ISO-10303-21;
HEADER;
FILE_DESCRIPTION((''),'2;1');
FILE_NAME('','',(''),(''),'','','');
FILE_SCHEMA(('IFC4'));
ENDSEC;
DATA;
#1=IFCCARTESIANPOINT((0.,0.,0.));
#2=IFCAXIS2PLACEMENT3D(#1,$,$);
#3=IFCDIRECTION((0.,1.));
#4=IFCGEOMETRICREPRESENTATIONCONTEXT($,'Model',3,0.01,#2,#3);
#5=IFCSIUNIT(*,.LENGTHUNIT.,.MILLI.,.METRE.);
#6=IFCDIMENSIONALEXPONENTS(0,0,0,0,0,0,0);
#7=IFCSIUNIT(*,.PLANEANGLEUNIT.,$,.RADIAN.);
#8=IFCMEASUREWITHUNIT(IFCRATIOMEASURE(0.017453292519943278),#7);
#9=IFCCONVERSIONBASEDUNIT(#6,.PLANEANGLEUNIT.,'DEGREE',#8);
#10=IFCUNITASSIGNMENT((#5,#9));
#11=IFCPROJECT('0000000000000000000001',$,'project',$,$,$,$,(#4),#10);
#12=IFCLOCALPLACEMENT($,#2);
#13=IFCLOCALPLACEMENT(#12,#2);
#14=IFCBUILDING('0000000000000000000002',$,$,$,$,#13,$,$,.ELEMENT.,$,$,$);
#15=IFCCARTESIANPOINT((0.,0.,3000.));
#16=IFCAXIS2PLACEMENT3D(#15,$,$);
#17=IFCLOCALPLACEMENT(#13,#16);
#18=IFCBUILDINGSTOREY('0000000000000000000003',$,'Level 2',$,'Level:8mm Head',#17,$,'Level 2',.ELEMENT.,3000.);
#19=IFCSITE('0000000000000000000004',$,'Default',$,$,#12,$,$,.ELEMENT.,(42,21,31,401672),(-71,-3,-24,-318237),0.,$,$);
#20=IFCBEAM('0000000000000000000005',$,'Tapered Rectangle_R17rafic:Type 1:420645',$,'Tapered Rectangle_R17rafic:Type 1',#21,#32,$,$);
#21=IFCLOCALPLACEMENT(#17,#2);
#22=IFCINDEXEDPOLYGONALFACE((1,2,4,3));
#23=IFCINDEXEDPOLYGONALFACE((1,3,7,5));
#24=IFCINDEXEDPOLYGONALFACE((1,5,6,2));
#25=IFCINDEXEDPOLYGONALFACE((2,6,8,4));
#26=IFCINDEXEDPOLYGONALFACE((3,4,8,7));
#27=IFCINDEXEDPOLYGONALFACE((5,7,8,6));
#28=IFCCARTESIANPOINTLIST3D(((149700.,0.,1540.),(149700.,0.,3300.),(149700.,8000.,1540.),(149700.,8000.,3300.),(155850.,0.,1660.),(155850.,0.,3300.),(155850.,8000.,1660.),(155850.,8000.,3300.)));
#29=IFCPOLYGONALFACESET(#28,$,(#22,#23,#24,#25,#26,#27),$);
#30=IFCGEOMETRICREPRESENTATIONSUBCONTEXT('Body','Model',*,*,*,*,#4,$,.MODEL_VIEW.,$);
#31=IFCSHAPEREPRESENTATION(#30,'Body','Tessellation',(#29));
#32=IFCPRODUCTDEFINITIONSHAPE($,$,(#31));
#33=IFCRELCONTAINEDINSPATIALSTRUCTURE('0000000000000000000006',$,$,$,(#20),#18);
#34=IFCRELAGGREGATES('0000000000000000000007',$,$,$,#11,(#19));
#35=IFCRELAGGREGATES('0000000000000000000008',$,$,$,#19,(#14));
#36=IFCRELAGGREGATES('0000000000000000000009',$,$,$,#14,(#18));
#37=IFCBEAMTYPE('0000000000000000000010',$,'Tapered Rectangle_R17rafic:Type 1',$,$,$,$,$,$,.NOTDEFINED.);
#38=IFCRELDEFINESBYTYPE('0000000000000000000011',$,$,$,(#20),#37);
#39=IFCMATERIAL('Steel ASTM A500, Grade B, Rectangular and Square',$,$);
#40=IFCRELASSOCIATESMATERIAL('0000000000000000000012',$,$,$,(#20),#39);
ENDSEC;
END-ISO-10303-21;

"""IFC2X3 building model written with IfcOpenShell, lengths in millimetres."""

from ifc_helpers import new_model, entity, si_unit, converted_unit, direction, frame, frame_2d, origin, place, context, subcontext, project, spatial, rectangle, extrude, clip, halfspace, material, type_object, element, save


model = new_model("IFC2X3")

# Units and contexts
model_context = context("Model", 3, precision=0.01, world=origin(), true_north=direction((0.0, 1.0)))
body_context = subcontext(model_context, "Body", "Model", "MODEL_VIEW")
ifc_project = project(units=[si_unit("LENGTHUNIT", "METRE", prefix="MILLI"), converted_unit("PLANEANGLEUNIT", "DEGREE", entity("IfcRatioMeasure", 0.017453292519943278), si_unit("PLANEANGLEUNIT", "RADIAN"), dimensions=[0, 0, 0, 0, 0, 0, 0])], contexts=[model_context])

# Site, building, storey
site_placement = place(None, origin())
site = spatial("IfcSite", under=ifc_project, at=site_placement, Name="Default", CompositionType="ELEMENT", RefLatitude=(42, 21, 31, 401672), RefLongitude=(-71, -3, -24, -318237), RefElevation=0.0)
building_placement = place(site_placement, origin())
building = spatial("IfcBuilding", under=site, at=building_placement, CompositionType="ELEMENT")
storey_placement = place(building_placement, frame((0.0, 0.0, 3000.0)))
storey = spatial("IfcBuildingStorey", under=building, at=storey_placement, Name="Level 2", ObjectType="Level:8mm Head", LongName="Level 2", CompositionType="ELEMENT", Elevation=3000.0)

# Beam
ifc_material = material(Name="Steel ASTM A500, Grade B, Rectangular and Square")
beam_type = type_object("IfcBeamType", Name="Tapered Rectangle_R17rafic:Type 1", PredefinedType="NOTDEFINED")
beam_1_placement = place(storey_placement, frame((149700.0, 4000.0, 3300.0)))
element("IfcBeam", 1, at=beam_1_placement, inside=storey, type_object=beam_type, material=ifc_material, Name="Tapered Rectangle_R17rafic:Type 1:420645", ObjectType="Tapered Rectangle_R17rafic:Type 1", context=body_context, shape_type="SweptSolid", body=[
    clip(extrude(rectangle(XDim=1760.0, YDim=8000.0, at=frame_2d((0.0, 0.0), x_axis=(0.0, 1.0))), frame((0.0, 0.0, -880.0), z_axis=(1.0, 0.0, 0.0), x_axis=(0.0, 1.0, 0.0)), (0.0, 0.0, 1.0), 6150.0), halfspace(frame((0.0, 0.0, -1760.0), z_axis=(0.019508, 0.0, -0.99981), x_axis=(0.0, 1.0, 0.0)), False)),
])

save(model, "model.ifc")
